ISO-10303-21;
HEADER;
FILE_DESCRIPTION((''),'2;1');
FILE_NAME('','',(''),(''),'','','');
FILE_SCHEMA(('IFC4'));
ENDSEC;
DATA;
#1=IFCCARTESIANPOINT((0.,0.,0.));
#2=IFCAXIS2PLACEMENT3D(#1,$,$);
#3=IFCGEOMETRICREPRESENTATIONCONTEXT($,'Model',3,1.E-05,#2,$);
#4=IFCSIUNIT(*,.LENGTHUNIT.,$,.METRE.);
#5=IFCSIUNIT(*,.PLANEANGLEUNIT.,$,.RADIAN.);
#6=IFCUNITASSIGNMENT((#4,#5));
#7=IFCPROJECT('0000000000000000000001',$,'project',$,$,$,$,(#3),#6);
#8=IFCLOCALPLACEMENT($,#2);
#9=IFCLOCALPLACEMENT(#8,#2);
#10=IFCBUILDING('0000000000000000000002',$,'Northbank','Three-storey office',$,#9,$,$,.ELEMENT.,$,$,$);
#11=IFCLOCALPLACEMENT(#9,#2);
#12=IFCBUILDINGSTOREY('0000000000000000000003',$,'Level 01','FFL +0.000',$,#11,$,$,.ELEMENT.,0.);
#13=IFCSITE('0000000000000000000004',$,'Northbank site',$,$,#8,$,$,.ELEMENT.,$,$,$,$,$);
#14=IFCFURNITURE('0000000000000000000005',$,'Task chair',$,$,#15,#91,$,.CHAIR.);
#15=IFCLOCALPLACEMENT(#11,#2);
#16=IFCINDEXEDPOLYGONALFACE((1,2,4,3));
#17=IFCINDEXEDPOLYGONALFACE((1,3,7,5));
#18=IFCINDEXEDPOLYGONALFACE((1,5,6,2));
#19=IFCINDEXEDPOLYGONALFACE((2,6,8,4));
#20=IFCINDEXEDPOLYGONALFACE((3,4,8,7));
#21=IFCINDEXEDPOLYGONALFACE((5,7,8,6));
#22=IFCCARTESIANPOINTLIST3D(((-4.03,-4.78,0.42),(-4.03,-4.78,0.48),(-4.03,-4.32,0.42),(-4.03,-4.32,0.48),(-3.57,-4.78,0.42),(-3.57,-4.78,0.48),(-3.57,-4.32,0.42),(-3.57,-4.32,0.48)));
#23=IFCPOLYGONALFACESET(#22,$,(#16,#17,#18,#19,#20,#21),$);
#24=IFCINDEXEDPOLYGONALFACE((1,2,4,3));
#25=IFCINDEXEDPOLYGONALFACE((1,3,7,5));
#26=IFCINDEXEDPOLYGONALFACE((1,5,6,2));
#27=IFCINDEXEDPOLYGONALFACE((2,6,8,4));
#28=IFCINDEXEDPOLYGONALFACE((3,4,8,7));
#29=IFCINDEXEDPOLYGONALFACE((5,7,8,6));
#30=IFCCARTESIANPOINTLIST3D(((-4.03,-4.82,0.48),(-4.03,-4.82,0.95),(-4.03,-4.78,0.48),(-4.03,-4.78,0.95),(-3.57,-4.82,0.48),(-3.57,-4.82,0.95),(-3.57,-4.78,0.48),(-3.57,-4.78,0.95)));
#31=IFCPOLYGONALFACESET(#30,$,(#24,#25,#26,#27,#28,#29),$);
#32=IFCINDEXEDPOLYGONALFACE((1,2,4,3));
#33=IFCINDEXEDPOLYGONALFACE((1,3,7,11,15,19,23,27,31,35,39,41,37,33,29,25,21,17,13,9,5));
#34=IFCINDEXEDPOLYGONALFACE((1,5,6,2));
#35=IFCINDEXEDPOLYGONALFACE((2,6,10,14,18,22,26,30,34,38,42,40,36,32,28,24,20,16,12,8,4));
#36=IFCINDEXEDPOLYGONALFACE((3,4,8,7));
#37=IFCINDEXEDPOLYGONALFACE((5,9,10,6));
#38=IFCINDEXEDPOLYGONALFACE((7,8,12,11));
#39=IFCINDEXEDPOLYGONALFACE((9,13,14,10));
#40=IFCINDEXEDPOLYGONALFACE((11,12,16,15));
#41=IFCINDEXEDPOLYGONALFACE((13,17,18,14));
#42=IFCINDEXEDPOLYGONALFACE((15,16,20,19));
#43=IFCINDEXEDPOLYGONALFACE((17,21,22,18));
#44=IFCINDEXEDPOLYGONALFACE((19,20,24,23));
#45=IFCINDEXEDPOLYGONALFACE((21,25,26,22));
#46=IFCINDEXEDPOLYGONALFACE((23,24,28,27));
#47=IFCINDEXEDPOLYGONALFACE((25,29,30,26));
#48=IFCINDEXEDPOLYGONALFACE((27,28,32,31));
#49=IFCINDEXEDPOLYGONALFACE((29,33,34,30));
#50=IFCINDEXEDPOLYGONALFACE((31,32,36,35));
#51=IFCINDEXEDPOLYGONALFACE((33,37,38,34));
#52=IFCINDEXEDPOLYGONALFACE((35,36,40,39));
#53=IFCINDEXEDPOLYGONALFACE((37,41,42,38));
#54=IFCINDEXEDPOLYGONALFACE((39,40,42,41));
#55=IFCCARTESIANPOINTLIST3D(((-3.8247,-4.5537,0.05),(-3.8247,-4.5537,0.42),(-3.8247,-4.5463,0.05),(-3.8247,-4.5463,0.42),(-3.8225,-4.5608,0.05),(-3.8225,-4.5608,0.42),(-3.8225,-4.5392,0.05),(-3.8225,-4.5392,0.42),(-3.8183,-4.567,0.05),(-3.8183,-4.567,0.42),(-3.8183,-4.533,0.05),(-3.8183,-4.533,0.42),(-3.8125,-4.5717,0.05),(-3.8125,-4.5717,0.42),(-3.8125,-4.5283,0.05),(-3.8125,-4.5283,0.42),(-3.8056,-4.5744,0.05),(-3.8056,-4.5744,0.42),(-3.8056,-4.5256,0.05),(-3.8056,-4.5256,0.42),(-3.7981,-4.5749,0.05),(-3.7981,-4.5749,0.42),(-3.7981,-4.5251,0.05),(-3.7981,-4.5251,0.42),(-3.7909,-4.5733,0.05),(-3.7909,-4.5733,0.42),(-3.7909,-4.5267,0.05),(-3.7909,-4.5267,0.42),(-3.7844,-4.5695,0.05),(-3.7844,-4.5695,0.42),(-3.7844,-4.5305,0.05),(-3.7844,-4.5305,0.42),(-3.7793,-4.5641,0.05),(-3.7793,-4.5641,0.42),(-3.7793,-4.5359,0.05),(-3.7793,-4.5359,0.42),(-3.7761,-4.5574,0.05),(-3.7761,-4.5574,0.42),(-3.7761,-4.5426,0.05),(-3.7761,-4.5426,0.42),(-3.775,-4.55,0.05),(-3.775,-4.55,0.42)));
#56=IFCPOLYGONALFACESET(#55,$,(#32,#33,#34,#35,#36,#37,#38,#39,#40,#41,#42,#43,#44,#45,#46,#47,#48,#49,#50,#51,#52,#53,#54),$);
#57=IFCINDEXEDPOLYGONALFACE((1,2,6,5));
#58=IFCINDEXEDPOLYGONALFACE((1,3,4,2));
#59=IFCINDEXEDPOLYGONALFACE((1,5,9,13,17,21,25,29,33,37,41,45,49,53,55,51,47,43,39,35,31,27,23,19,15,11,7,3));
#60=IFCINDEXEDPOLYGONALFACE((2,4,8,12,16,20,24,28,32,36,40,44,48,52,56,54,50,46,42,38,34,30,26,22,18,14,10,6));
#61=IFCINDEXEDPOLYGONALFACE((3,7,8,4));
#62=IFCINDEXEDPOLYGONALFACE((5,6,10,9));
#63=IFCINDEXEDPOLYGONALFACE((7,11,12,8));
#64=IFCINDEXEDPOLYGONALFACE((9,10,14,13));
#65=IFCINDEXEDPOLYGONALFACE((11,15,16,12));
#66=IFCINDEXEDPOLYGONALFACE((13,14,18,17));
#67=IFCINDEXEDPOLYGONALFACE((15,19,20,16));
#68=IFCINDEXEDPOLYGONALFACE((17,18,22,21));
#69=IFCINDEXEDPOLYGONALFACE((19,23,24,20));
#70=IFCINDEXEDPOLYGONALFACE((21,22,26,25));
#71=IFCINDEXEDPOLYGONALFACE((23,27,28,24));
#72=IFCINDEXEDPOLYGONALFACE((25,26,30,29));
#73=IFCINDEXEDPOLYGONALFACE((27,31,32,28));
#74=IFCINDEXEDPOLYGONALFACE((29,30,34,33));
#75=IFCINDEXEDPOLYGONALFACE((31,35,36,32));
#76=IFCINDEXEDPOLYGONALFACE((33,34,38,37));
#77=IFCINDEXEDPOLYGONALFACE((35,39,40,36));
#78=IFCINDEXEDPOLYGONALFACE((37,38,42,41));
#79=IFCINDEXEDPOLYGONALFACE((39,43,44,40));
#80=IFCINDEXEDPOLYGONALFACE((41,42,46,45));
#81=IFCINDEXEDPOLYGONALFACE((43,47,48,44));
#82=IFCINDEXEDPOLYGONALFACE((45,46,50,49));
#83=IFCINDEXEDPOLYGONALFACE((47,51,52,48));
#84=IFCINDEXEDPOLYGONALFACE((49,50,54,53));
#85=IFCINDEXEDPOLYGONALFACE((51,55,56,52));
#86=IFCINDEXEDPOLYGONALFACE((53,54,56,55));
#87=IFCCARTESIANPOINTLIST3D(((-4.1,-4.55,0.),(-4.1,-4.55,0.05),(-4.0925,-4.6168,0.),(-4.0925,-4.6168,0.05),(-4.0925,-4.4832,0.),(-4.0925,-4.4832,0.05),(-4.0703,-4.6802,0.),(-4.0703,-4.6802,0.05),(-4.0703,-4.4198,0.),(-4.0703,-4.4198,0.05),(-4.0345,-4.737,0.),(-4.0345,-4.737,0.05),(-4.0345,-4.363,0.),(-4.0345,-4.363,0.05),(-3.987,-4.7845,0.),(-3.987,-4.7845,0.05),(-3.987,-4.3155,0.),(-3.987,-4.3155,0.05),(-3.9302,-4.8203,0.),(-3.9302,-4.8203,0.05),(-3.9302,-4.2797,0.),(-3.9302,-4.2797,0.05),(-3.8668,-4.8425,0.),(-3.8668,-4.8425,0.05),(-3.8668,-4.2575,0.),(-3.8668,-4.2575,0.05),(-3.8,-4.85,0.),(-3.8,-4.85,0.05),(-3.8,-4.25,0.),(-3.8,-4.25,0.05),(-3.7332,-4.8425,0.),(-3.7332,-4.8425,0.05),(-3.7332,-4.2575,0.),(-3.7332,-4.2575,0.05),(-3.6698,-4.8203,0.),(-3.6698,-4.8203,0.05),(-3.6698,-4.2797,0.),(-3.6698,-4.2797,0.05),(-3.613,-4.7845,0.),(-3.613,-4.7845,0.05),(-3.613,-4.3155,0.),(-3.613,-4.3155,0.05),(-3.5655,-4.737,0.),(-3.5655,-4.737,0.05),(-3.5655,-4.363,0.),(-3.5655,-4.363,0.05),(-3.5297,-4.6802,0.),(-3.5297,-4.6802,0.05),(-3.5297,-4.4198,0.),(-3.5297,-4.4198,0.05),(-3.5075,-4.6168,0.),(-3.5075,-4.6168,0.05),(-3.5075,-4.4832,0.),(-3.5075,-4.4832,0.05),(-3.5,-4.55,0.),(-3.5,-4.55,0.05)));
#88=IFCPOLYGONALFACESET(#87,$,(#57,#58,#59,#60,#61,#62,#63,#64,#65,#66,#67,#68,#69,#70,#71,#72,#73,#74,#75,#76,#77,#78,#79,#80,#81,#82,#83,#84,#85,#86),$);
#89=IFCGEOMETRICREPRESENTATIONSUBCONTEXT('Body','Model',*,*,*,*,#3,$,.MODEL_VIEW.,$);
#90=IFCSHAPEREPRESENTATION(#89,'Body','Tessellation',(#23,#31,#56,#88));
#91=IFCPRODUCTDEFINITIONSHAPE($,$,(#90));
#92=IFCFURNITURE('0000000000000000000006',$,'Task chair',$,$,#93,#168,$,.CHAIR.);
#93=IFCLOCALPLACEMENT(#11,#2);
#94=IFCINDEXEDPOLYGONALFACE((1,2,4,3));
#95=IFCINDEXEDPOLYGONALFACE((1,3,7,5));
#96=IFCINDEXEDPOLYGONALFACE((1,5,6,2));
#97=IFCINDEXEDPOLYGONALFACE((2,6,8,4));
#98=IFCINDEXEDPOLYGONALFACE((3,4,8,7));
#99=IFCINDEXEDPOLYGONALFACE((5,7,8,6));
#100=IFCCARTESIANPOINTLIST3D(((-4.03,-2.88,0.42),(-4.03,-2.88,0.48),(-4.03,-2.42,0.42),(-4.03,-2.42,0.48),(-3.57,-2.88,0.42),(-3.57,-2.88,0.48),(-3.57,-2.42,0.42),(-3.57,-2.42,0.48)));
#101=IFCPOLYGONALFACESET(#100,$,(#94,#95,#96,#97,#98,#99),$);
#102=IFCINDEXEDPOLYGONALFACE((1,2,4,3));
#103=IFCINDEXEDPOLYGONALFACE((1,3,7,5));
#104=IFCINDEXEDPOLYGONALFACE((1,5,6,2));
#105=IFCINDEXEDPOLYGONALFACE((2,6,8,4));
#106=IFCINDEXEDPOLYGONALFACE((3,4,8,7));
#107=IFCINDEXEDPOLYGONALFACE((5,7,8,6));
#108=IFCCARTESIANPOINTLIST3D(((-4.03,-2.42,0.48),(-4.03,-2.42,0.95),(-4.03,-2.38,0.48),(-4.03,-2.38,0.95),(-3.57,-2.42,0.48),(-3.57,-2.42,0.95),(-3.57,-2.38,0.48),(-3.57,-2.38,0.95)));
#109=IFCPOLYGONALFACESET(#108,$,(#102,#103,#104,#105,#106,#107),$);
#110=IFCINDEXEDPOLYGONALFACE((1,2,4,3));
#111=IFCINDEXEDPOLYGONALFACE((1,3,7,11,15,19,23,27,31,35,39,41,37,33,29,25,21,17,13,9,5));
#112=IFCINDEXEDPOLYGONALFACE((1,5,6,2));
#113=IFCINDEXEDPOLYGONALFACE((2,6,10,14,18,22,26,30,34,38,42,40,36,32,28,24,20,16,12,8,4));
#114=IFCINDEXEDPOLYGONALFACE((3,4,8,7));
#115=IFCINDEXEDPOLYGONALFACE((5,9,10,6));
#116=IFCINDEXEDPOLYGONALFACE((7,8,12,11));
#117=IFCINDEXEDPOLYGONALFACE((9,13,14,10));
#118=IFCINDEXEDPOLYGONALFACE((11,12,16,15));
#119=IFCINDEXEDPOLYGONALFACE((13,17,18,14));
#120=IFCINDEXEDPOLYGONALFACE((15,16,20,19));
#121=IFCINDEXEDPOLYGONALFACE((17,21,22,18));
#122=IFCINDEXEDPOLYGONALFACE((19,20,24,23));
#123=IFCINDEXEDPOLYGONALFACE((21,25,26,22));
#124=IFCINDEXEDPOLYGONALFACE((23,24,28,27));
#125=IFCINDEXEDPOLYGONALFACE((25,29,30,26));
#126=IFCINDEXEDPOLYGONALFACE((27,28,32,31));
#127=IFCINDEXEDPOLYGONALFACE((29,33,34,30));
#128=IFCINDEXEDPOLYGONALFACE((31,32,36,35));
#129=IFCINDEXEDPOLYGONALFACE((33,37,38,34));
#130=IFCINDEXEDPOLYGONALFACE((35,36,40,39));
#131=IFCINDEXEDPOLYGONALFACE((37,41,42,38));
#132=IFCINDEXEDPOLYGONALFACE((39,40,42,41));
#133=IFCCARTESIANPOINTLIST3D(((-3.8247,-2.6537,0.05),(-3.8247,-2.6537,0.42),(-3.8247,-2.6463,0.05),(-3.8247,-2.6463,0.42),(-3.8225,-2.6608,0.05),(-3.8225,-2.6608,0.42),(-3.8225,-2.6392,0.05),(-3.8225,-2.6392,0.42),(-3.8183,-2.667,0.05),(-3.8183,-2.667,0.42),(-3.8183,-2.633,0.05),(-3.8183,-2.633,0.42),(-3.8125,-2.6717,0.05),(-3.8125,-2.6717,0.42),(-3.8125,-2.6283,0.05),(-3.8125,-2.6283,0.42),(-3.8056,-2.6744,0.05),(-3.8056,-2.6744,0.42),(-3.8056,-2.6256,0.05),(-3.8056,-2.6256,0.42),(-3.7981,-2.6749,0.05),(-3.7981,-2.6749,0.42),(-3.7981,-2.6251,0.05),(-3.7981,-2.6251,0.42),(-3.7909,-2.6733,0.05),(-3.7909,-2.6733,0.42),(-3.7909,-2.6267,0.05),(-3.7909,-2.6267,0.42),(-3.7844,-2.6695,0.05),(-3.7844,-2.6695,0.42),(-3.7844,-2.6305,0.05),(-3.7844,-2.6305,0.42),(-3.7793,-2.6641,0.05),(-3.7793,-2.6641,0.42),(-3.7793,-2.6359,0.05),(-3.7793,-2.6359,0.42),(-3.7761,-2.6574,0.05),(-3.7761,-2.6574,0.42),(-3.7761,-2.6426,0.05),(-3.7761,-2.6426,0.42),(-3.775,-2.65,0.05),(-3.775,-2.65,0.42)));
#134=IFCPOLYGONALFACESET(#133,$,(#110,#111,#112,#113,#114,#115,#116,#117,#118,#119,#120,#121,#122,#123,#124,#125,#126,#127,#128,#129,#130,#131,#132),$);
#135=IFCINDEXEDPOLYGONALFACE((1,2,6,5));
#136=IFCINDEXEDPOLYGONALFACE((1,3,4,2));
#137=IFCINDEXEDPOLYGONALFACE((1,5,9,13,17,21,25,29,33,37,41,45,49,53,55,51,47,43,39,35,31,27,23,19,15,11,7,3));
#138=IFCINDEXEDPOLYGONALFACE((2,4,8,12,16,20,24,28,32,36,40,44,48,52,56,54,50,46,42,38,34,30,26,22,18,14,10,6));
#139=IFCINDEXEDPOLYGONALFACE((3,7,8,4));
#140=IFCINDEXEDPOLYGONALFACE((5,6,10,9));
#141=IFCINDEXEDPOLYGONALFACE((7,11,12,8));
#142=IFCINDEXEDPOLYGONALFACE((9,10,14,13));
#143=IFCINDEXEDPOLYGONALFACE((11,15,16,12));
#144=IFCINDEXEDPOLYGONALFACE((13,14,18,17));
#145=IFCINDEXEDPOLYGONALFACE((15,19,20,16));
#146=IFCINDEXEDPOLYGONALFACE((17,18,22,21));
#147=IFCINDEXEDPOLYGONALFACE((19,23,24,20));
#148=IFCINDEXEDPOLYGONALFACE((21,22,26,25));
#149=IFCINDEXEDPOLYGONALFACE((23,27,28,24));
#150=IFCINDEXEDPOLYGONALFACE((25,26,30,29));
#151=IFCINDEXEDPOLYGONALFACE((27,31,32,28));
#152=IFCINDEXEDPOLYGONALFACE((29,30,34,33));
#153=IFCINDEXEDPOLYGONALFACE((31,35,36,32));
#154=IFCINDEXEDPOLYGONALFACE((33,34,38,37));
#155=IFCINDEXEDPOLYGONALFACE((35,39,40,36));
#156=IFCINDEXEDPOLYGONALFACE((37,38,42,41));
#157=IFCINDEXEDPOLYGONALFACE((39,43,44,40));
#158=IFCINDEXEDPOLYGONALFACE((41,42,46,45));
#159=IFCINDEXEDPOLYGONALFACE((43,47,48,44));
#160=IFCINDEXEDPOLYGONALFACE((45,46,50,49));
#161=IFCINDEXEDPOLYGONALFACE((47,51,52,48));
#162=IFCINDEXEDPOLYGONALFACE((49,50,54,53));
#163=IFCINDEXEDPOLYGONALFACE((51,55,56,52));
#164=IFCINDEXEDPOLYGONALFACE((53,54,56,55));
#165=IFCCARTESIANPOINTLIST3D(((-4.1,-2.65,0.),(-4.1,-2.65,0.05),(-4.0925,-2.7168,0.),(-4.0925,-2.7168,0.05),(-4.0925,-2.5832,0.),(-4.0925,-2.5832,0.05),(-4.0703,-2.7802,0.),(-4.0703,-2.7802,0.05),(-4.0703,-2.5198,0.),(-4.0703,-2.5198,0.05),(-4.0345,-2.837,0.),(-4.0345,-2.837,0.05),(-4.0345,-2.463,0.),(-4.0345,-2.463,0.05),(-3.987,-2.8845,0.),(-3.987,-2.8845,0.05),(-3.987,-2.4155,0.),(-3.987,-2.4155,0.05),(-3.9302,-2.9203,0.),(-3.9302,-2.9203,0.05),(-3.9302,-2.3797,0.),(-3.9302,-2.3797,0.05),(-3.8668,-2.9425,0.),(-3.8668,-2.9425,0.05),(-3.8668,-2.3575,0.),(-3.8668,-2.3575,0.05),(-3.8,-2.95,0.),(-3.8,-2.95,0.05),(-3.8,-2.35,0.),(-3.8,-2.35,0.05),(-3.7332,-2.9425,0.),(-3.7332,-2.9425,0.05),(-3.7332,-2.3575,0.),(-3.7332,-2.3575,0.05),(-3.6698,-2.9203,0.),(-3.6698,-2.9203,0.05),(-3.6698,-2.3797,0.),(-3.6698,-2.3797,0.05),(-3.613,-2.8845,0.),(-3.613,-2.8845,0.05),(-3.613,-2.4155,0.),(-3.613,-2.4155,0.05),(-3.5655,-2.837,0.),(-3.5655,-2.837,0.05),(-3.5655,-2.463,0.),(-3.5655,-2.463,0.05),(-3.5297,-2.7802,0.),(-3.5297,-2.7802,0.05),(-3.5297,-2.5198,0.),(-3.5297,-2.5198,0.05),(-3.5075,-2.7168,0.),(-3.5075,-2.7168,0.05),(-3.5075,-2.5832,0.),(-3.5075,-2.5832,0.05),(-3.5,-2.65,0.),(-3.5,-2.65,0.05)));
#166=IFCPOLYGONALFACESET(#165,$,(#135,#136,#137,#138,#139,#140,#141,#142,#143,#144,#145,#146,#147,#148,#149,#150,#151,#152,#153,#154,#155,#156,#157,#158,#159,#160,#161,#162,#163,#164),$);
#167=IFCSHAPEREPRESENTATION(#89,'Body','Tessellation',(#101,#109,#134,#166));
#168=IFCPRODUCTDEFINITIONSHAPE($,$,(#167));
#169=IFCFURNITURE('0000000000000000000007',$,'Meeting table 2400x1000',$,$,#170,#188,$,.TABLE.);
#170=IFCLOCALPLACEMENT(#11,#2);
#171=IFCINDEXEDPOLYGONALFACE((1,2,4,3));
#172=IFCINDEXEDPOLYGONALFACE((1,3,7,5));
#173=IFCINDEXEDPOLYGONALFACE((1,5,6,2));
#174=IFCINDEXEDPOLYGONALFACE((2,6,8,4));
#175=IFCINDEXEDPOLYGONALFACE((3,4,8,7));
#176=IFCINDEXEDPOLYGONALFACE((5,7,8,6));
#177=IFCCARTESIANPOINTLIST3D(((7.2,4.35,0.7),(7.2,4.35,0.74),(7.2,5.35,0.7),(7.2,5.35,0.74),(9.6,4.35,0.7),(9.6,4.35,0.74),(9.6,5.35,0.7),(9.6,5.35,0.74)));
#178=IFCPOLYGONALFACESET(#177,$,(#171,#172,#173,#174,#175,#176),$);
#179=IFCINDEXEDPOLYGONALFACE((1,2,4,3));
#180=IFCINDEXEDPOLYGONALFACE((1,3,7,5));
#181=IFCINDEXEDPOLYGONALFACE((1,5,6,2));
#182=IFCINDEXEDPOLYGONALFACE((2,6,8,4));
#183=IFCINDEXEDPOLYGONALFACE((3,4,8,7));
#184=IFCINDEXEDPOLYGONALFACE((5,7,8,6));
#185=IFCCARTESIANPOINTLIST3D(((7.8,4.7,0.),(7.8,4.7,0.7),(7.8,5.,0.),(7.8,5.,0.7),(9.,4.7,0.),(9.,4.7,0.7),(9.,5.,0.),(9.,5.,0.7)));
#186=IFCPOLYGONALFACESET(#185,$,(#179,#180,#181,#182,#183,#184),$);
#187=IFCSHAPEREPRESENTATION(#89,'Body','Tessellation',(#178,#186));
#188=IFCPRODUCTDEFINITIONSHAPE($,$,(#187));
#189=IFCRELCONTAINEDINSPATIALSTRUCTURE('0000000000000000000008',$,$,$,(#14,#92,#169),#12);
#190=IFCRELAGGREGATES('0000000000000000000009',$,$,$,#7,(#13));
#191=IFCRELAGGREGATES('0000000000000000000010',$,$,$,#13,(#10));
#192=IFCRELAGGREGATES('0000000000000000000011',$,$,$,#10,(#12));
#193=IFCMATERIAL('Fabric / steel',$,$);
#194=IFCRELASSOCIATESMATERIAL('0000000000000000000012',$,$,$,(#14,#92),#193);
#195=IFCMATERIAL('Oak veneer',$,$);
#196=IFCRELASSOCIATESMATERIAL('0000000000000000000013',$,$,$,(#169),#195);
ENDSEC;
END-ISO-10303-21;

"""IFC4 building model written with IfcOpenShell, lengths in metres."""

from ifc_helpers import new_model, si_unit, frame, origin, place, context, subcontext, project, spatial, rectangle, circle, extrude, material, element, save


model = new_model("IFC4")

# Units and contexts
model_context = context("Model", 3, precision=1e-05, world=origin())
body_context = subcontext(model_context, "Body", "Model", "MODEL_VIEW")
ifc_project = project(units=[si_unit("LENGTHUNIT", "METRE"), si_unit("PLANEANGLEUNIT", "RADIAN")], contexts=[model_context])

# Site, building, storey
site_placement = place(None, origin())
site = spatial("IfcSite", under=ifc_project, at=site_placement, Name="Northbank site", CompositionType="ELEMENT")
building_placement = place(site_placement, origin())
building = spatial("IfcBuilding", under=site, at=building_placement, Name="Northbank", Description="Three-storey office", CompositionType="ELEMENT")
storey_placement = place(building_placement, origin())
storey = spatial("IfcBuildingStorey", under=building, at=storey_placement, Name="Level 01", Description="FFL +0.000", CompositionType="ELEMENT", Elevation=0.0)

# Furniture
ifc_material_1 = material(Name="Fabric / steel")
furniture_1_placement = place(storey_placement, origin())
element("IfcFurniture", 1, at=furniture_1_placement, inside=storey, material=ifc_material_1, Name="Task chair", PredefinedType="CHAIR", context=body_context, shape_type="SweptSolid", body=[
    extrude(rectangle(XDim=0.46, YDim=0.46), frame((-3.8, -4.55, 0.42)), (0.0, 0.0, 1.0), 0.06),
    extrude(rectangle(XDim=0.46, YDim=0.04), frame((-3.8, -4.8, 0.48)), (0.0, 0.0, 1.0), 0.47),
    extrude(circle(Radius=0.025), frame((-3.8, -4.55, 0.05), z_axis=(0.0, 0.0, 1.0), x_axis=(1.0, 0.0, 0.0)), (0.0, 0.0, 1.0), 0.37),
    extrude(circle(Radius=0.3), frame((-3.8, -4.55, 0.0), z_axis=(0.0, 0.0, 1.0), x_axis=(1.0, 0.0, 0.0)), (0.0, 0.0, 1.0), 0.05),
])
furniture_2_placement = place(storey_placement, origin())
element("IfcFurniture", 2, at=furniture_2_placement, inside=storey, material=ifc_material_1, Name="Task chair", PredefinedType="CHAIR", context=body_context, shape_type="SweptSolid", body=[
    extrude(rectangle(XDim=0.46, YDim=0.46), frame((-3.8, -2.65, 0.42)), (0.0, 0.0, 1.0), 0.06),
    extrude(rectangle(XDim=0.46, YDim=0.04), frame((-3.8, -2.4, 0.48)), (0.0, 0.0, 1.0), 0.47),
    extrude(circle(Radius=0.025), frame((-3.8, -2.65, 0.05), z_axis=(0.0, 0.0, 1.0), x_axis=(1.0, 0.0, 0.0)), (0.0, 0.0, 1.0), 0.37),
    extrude(circle(Radius=0.3), frame((-3.8, -2.65, 0.0), z_axis=(0.0, 0.0, 1.0), x_axis=(1.0, 0.0, 0.0)), (0.0, 0.0, 1.0), 0.05),
])
ifc_material_2 = material(Name="Oak veneer")
furniture_3_placement = place(storey_placement, origin())
element("IfcFurniture", 3, at=furniture_3_placement, inside=storey, material=ifc_material_2, Name="Meeting table 2400x1000", PredefinedType="TABLE", context=body_context, shape_type="SweptSolid", body=[
    extrude(rectangle(XDim=2.4, YDim=1.0), frame((8.4, 4.85, 0.7)), (0.0, 0.0, 1.0), 0.04),
    extrude(rectangle(XDim=1.2, YDim=0.3), frame((8.4, 4.85, 0.0)), (0.0, 0.0, 1.0), 0.7),
])

save(model, "model.ifc")
